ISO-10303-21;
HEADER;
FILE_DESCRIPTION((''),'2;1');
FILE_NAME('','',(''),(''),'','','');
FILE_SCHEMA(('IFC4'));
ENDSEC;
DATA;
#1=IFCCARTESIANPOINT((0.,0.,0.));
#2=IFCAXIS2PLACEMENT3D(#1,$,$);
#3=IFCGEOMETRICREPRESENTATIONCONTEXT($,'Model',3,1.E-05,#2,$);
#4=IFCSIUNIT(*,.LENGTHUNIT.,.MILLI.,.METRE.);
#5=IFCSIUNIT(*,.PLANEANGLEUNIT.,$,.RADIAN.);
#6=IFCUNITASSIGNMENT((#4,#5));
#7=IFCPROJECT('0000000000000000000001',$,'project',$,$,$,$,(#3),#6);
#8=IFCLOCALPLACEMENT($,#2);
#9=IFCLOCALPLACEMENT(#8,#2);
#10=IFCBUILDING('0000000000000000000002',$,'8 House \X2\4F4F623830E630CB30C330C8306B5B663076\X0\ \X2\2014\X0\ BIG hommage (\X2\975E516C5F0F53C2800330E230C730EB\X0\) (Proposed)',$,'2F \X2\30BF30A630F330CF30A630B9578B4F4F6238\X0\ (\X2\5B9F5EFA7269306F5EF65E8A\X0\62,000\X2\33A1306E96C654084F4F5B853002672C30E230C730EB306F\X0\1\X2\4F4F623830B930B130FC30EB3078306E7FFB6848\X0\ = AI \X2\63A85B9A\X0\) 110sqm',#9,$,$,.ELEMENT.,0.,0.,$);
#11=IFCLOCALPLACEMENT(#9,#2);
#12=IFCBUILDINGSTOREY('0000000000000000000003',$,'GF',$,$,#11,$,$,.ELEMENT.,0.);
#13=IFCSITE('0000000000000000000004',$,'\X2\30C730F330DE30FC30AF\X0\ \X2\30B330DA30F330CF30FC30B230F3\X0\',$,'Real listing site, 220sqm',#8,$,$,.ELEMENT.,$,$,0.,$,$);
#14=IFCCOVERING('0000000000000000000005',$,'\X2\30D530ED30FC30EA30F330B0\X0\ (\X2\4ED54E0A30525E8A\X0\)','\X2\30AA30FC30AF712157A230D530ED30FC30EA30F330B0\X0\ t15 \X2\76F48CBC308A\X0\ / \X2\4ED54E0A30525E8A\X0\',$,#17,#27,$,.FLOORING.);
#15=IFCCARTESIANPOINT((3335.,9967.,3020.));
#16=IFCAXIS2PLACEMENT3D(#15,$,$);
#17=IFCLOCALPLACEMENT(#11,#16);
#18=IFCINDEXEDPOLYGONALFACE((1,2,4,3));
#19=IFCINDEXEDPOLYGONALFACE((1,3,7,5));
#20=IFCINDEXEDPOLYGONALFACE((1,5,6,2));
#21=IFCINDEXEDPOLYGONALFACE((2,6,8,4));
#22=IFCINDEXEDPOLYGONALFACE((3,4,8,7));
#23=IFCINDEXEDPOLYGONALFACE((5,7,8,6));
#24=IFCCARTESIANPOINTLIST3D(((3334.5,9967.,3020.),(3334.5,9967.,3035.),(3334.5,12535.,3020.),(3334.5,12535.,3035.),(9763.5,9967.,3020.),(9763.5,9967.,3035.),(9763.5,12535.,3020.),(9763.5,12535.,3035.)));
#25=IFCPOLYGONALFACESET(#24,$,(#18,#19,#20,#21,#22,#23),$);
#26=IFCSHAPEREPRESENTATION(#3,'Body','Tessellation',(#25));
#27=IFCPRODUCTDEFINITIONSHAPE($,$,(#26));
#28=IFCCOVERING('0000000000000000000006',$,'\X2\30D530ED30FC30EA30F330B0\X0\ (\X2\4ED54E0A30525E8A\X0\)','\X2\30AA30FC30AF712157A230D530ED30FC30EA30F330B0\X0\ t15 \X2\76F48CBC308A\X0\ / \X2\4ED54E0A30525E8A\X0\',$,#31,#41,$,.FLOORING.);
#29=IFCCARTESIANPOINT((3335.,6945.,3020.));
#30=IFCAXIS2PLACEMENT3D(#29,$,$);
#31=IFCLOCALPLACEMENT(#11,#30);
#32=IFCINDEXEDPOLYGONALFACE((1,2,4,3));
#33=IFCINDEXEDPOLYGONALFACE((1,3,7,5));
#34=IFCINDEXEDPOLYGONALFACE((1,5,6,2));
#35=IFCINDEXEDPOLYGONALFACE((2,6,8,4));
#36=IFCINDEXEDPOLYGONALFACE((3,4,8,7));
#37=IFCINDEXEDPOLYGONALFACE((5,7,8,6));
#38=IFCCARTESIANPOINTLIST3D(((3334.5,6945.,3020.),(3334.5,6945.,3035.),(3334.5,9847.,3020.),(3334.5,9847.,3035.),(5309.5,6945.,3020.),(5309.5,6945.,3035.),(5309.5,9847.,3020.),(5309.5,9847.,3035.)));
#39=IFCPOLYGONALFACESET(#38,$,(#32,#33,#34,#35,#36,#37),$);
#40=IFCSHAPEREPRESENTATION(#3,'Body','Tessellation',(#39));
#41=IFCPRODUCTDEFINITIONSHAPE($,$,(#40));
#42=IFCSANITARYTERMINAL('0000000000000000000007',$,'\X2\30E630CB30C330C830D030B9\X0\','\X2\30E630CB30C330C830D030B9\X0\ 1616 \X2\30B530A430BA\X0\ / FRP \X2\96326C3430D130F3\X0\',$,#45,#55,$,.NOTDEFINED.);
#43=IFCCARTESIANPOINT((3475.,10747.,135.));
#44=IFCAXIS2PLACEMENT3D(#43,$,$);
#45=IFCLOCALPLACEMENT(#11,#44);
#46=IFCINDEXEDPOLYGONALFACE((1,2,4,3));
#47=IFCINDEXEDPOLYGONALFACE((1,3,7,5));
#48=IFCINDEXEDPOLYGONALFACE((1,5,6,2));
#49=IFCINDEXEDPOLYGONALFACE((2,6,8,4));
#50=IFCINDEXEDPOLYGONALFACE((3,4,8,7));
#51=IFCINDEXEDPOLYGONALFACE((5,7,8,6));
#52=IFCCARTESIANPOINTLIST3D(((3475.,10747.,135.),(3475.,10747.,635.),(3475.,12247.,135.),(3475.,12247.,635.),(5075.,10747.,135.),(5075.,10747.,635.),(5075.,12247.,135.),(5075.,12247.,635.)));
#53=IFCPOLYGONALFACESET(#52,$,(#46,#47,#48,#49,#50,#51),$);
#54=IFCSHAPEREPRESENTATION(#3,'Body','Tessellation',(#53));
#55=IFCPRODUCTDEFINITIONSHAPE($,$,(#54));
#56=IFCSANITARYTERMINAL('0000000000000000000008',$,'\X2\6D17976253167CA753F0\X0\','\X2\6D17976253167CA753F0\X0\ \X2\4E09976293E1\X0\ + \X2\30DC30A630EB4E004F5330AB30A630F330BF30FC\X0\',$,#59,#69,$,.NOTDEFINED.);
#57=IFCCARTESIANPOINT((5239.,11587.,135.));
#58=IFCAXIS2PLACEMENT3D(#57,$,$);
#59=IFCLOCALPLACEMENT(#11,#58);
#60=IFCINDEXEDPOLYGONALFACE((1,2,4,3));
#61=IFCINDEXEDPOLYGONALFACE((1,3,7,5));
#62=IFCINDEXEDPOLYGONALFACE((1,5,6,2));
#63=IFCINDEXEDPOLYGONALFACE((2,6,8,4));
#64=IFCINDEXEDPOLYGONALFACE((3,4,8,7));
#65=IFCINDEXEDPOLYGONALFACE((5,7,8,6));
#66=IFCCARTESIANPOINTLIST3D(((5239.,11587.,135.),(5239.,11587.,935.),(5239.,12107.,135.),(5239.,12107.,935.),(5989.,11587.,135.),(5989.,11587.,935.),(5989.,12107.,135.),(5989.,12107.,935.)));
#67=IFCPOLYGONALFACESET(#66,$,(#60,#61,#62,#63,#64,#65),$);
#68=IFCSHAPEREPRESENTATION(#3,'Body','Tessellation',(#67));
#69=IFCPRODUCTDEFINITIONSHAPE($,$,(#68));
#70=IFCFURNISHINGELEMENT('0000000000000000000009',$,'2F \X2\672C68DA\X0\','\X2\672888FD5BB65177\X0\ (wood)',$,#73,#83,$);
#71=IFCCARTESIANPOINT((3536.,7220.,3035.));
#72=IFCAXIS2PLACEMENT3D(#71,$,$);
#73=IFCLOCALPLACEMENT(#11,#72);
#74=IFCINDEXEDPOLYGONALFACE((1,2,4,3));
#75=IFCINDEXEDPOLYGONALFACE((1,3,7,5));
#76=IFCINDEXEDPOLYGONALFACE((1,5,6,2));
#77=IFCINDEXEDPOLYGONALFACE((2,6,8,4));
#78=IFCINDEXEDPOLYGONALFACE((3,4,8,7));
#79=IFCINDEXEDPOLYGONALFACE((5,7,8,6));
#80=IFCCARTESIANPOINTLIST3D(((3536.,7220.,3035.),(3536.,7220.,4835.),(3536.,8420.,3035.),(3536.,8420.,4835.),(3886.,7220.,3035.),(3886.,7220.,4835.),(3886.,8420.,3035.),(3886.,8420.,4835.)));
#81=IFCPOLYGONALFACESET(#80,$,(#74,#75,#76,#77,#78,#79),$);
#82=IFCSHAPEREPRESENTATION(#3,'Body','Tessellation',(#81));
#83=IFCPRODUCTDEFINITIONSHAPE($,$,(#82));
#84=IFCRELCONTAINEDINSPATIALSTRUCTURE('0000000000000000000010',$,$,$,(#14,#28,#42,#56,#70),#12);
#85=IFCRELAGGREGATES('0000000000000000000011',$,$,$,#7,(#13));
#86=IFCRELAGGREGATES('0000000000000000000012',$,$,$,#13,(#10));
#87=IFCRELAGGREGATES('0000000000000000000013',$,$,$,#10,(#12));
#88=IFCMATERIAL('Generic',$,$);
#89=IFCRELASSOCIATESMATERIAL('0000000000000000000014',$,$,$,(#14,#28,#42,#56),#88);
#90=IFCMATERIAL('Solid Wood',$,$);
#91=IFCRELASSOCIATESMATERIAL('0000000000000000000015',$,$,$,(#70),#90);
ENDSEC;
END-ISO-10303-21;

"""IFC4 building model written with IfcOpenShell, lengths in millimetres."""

from ifc_helpers import new_model, si_unit, frame, frame_2d, origin, place, context, project, spatial, rectangle, extrude, material, element, save


model = new_model("IFC4")

# Units and contexts
model_context = context("Model", 3, precision=1e-05, world=origin())
ifc_project = project(units=[si_unit("LENGTHUNIT", "METRE", prefix="MILLI"), si_unit("PLANEANGLEUNIT", "RADIAN")], contexts=[model_context])

# Site, building, storey
site_placement = place(None, origin())
site = spatial("IfcSite", under=ifc_project, at=site_placement, Name="デンマーク コペンハーゲン", ObjectType="Real listing site, 220sqm", CompositionType="ELEMENT", RefElevation=0.0)
building_placement = place(site_placement, origin())
building = spatial("IfcBuilding", under=site, at=building_placement, Name="8 House 住戸ユニットに学ぶ — BIG hommage (非公式参考モデル) (Proposed)", ObjectType="2F タウンハウス型住戸 (実建物は延床62,000㎡の集合住宅。本モデルは1住戸スケールへの翻案 = AI 推定) 110sqm", CompositionType="ELEMENT", ElevationOfRefHeight=0.0, ElevationOfTerrain=0.0)
storey_placement = place(building_placement, origin())
storey = spatial("IfcBuildingStorey", under=building, at=storey_placement, Name="GF", CompositionType="ELEMENT", Elevation=0.0)

# Shared definitions
ifc_material_1 = material(Name="Solid Wood")

# Coverings
ifc_material_2 = material(Name="Generic")
covering_1_placement = place(storey_placement, frame((3335.0, 9967.0, 3020.0)))
element("IfcCovering", 1, at=covering_1_placement, inside=storey, material=ifc_material_2, Name="フローリング (仕上げ床)", Description="オーク無垢フローリング t15 直貼り / 仕上げ床", PredefinedType="FLOORING", context=model_context, shape_type="SweptSolid", body=[
    extrude(rectangle(XDim=6429.0, YDim=2568.0, at=frame_2d((3214.0, 1284.0))), frame((3335.0, 9967.0, 3020.0)), (0.0, 0.0, 1.0), 15.0),
])
covering_2_placement = place(storey_placement, frame((3335.0, 6945.0, 3020.0)))
element("IfcCovering", 2, at=covering_2_placement, inside=storey, material=ifc_material_2, Name="フローリング (仕上げ床)", Description="オーク無垢フローリング t15 直貼り / 仕上げ床", PredefinedType="FLOORING", context=model_context, shape_type="SweptSolid", body=[
    extrude(rectangle(XDim=1975.0, YDim=2902.0, at=frame_2d((987.0, 1451.0))), frame((3335.0, 6945.0, 3020.0)), (0.0, 0.0, 1.0), 15.0),
])

# Sanitary terminals
sanitary_terminal_1_placement = place(storey_placement, frame((3475.0, 10747.0, 135.0)))
element("IfcSanitaryTerminal", 3, at=sanitary_terminal_1_placement, inside=storey, material=ifc_material_2, Name="ユニットバス", Description="ユニットバス 1616 サイズ / FRP 防水パン", PredefinedType="NOTDEFINED", context=model_context, shape_type="SweptSolid", body=[
    extrude(rectangle(XDim=1600.0, YDim=1500.0, at=frame_2d((800.0, 750.0))), frame((3475.0, 10747.0, 135.0)), (0.0, 0.0, 1.0), 500.0),
])
sanitary_terminal_2_placement = place(storey_placement, frame((5239.0, 11587.0, 135.0)))
element("IfcSanitaryTerminal", 4, at=sanitary_terminal_2_placement, inside=storey, material=ifc_material_2, Name="洗面化粧台", Description="洗面化粧台 三面鏡 + ボウル一体カウンター", PredefinedType="NOTDEFINED", context=model_context, shape_type="SweptSolid", body=[
    extrude(rectangle(XDim=750.0, YDim=520.0, at=frame_2d((375.0, 260.0))), frame((5239.0, 11587.0, 135.0)), (0.0, 0.0, 1.0), 800.0),
])

# Furnishing element
furnishing_placement = place(storey_placement, frame((3536.0, 7220.0, 3035.0)))
element("IfcFurnishingElement", 5, at=furnishing_placement, inside=storey, material=ifc_material_1, Name="2F 本棚", Description="木製家具 (wood)", context=model_context, shape_type="SweptSolid", body=[
    extrude(rectangle(XDim=350.0, YDim=1200.0, at=frame_2d((175.0, 600.0))), frame((3536.0, 7220.0, 3035.0)), (0.0, 0.0, 1.0), 1800.0),
])

save(model, "model.ifc")
